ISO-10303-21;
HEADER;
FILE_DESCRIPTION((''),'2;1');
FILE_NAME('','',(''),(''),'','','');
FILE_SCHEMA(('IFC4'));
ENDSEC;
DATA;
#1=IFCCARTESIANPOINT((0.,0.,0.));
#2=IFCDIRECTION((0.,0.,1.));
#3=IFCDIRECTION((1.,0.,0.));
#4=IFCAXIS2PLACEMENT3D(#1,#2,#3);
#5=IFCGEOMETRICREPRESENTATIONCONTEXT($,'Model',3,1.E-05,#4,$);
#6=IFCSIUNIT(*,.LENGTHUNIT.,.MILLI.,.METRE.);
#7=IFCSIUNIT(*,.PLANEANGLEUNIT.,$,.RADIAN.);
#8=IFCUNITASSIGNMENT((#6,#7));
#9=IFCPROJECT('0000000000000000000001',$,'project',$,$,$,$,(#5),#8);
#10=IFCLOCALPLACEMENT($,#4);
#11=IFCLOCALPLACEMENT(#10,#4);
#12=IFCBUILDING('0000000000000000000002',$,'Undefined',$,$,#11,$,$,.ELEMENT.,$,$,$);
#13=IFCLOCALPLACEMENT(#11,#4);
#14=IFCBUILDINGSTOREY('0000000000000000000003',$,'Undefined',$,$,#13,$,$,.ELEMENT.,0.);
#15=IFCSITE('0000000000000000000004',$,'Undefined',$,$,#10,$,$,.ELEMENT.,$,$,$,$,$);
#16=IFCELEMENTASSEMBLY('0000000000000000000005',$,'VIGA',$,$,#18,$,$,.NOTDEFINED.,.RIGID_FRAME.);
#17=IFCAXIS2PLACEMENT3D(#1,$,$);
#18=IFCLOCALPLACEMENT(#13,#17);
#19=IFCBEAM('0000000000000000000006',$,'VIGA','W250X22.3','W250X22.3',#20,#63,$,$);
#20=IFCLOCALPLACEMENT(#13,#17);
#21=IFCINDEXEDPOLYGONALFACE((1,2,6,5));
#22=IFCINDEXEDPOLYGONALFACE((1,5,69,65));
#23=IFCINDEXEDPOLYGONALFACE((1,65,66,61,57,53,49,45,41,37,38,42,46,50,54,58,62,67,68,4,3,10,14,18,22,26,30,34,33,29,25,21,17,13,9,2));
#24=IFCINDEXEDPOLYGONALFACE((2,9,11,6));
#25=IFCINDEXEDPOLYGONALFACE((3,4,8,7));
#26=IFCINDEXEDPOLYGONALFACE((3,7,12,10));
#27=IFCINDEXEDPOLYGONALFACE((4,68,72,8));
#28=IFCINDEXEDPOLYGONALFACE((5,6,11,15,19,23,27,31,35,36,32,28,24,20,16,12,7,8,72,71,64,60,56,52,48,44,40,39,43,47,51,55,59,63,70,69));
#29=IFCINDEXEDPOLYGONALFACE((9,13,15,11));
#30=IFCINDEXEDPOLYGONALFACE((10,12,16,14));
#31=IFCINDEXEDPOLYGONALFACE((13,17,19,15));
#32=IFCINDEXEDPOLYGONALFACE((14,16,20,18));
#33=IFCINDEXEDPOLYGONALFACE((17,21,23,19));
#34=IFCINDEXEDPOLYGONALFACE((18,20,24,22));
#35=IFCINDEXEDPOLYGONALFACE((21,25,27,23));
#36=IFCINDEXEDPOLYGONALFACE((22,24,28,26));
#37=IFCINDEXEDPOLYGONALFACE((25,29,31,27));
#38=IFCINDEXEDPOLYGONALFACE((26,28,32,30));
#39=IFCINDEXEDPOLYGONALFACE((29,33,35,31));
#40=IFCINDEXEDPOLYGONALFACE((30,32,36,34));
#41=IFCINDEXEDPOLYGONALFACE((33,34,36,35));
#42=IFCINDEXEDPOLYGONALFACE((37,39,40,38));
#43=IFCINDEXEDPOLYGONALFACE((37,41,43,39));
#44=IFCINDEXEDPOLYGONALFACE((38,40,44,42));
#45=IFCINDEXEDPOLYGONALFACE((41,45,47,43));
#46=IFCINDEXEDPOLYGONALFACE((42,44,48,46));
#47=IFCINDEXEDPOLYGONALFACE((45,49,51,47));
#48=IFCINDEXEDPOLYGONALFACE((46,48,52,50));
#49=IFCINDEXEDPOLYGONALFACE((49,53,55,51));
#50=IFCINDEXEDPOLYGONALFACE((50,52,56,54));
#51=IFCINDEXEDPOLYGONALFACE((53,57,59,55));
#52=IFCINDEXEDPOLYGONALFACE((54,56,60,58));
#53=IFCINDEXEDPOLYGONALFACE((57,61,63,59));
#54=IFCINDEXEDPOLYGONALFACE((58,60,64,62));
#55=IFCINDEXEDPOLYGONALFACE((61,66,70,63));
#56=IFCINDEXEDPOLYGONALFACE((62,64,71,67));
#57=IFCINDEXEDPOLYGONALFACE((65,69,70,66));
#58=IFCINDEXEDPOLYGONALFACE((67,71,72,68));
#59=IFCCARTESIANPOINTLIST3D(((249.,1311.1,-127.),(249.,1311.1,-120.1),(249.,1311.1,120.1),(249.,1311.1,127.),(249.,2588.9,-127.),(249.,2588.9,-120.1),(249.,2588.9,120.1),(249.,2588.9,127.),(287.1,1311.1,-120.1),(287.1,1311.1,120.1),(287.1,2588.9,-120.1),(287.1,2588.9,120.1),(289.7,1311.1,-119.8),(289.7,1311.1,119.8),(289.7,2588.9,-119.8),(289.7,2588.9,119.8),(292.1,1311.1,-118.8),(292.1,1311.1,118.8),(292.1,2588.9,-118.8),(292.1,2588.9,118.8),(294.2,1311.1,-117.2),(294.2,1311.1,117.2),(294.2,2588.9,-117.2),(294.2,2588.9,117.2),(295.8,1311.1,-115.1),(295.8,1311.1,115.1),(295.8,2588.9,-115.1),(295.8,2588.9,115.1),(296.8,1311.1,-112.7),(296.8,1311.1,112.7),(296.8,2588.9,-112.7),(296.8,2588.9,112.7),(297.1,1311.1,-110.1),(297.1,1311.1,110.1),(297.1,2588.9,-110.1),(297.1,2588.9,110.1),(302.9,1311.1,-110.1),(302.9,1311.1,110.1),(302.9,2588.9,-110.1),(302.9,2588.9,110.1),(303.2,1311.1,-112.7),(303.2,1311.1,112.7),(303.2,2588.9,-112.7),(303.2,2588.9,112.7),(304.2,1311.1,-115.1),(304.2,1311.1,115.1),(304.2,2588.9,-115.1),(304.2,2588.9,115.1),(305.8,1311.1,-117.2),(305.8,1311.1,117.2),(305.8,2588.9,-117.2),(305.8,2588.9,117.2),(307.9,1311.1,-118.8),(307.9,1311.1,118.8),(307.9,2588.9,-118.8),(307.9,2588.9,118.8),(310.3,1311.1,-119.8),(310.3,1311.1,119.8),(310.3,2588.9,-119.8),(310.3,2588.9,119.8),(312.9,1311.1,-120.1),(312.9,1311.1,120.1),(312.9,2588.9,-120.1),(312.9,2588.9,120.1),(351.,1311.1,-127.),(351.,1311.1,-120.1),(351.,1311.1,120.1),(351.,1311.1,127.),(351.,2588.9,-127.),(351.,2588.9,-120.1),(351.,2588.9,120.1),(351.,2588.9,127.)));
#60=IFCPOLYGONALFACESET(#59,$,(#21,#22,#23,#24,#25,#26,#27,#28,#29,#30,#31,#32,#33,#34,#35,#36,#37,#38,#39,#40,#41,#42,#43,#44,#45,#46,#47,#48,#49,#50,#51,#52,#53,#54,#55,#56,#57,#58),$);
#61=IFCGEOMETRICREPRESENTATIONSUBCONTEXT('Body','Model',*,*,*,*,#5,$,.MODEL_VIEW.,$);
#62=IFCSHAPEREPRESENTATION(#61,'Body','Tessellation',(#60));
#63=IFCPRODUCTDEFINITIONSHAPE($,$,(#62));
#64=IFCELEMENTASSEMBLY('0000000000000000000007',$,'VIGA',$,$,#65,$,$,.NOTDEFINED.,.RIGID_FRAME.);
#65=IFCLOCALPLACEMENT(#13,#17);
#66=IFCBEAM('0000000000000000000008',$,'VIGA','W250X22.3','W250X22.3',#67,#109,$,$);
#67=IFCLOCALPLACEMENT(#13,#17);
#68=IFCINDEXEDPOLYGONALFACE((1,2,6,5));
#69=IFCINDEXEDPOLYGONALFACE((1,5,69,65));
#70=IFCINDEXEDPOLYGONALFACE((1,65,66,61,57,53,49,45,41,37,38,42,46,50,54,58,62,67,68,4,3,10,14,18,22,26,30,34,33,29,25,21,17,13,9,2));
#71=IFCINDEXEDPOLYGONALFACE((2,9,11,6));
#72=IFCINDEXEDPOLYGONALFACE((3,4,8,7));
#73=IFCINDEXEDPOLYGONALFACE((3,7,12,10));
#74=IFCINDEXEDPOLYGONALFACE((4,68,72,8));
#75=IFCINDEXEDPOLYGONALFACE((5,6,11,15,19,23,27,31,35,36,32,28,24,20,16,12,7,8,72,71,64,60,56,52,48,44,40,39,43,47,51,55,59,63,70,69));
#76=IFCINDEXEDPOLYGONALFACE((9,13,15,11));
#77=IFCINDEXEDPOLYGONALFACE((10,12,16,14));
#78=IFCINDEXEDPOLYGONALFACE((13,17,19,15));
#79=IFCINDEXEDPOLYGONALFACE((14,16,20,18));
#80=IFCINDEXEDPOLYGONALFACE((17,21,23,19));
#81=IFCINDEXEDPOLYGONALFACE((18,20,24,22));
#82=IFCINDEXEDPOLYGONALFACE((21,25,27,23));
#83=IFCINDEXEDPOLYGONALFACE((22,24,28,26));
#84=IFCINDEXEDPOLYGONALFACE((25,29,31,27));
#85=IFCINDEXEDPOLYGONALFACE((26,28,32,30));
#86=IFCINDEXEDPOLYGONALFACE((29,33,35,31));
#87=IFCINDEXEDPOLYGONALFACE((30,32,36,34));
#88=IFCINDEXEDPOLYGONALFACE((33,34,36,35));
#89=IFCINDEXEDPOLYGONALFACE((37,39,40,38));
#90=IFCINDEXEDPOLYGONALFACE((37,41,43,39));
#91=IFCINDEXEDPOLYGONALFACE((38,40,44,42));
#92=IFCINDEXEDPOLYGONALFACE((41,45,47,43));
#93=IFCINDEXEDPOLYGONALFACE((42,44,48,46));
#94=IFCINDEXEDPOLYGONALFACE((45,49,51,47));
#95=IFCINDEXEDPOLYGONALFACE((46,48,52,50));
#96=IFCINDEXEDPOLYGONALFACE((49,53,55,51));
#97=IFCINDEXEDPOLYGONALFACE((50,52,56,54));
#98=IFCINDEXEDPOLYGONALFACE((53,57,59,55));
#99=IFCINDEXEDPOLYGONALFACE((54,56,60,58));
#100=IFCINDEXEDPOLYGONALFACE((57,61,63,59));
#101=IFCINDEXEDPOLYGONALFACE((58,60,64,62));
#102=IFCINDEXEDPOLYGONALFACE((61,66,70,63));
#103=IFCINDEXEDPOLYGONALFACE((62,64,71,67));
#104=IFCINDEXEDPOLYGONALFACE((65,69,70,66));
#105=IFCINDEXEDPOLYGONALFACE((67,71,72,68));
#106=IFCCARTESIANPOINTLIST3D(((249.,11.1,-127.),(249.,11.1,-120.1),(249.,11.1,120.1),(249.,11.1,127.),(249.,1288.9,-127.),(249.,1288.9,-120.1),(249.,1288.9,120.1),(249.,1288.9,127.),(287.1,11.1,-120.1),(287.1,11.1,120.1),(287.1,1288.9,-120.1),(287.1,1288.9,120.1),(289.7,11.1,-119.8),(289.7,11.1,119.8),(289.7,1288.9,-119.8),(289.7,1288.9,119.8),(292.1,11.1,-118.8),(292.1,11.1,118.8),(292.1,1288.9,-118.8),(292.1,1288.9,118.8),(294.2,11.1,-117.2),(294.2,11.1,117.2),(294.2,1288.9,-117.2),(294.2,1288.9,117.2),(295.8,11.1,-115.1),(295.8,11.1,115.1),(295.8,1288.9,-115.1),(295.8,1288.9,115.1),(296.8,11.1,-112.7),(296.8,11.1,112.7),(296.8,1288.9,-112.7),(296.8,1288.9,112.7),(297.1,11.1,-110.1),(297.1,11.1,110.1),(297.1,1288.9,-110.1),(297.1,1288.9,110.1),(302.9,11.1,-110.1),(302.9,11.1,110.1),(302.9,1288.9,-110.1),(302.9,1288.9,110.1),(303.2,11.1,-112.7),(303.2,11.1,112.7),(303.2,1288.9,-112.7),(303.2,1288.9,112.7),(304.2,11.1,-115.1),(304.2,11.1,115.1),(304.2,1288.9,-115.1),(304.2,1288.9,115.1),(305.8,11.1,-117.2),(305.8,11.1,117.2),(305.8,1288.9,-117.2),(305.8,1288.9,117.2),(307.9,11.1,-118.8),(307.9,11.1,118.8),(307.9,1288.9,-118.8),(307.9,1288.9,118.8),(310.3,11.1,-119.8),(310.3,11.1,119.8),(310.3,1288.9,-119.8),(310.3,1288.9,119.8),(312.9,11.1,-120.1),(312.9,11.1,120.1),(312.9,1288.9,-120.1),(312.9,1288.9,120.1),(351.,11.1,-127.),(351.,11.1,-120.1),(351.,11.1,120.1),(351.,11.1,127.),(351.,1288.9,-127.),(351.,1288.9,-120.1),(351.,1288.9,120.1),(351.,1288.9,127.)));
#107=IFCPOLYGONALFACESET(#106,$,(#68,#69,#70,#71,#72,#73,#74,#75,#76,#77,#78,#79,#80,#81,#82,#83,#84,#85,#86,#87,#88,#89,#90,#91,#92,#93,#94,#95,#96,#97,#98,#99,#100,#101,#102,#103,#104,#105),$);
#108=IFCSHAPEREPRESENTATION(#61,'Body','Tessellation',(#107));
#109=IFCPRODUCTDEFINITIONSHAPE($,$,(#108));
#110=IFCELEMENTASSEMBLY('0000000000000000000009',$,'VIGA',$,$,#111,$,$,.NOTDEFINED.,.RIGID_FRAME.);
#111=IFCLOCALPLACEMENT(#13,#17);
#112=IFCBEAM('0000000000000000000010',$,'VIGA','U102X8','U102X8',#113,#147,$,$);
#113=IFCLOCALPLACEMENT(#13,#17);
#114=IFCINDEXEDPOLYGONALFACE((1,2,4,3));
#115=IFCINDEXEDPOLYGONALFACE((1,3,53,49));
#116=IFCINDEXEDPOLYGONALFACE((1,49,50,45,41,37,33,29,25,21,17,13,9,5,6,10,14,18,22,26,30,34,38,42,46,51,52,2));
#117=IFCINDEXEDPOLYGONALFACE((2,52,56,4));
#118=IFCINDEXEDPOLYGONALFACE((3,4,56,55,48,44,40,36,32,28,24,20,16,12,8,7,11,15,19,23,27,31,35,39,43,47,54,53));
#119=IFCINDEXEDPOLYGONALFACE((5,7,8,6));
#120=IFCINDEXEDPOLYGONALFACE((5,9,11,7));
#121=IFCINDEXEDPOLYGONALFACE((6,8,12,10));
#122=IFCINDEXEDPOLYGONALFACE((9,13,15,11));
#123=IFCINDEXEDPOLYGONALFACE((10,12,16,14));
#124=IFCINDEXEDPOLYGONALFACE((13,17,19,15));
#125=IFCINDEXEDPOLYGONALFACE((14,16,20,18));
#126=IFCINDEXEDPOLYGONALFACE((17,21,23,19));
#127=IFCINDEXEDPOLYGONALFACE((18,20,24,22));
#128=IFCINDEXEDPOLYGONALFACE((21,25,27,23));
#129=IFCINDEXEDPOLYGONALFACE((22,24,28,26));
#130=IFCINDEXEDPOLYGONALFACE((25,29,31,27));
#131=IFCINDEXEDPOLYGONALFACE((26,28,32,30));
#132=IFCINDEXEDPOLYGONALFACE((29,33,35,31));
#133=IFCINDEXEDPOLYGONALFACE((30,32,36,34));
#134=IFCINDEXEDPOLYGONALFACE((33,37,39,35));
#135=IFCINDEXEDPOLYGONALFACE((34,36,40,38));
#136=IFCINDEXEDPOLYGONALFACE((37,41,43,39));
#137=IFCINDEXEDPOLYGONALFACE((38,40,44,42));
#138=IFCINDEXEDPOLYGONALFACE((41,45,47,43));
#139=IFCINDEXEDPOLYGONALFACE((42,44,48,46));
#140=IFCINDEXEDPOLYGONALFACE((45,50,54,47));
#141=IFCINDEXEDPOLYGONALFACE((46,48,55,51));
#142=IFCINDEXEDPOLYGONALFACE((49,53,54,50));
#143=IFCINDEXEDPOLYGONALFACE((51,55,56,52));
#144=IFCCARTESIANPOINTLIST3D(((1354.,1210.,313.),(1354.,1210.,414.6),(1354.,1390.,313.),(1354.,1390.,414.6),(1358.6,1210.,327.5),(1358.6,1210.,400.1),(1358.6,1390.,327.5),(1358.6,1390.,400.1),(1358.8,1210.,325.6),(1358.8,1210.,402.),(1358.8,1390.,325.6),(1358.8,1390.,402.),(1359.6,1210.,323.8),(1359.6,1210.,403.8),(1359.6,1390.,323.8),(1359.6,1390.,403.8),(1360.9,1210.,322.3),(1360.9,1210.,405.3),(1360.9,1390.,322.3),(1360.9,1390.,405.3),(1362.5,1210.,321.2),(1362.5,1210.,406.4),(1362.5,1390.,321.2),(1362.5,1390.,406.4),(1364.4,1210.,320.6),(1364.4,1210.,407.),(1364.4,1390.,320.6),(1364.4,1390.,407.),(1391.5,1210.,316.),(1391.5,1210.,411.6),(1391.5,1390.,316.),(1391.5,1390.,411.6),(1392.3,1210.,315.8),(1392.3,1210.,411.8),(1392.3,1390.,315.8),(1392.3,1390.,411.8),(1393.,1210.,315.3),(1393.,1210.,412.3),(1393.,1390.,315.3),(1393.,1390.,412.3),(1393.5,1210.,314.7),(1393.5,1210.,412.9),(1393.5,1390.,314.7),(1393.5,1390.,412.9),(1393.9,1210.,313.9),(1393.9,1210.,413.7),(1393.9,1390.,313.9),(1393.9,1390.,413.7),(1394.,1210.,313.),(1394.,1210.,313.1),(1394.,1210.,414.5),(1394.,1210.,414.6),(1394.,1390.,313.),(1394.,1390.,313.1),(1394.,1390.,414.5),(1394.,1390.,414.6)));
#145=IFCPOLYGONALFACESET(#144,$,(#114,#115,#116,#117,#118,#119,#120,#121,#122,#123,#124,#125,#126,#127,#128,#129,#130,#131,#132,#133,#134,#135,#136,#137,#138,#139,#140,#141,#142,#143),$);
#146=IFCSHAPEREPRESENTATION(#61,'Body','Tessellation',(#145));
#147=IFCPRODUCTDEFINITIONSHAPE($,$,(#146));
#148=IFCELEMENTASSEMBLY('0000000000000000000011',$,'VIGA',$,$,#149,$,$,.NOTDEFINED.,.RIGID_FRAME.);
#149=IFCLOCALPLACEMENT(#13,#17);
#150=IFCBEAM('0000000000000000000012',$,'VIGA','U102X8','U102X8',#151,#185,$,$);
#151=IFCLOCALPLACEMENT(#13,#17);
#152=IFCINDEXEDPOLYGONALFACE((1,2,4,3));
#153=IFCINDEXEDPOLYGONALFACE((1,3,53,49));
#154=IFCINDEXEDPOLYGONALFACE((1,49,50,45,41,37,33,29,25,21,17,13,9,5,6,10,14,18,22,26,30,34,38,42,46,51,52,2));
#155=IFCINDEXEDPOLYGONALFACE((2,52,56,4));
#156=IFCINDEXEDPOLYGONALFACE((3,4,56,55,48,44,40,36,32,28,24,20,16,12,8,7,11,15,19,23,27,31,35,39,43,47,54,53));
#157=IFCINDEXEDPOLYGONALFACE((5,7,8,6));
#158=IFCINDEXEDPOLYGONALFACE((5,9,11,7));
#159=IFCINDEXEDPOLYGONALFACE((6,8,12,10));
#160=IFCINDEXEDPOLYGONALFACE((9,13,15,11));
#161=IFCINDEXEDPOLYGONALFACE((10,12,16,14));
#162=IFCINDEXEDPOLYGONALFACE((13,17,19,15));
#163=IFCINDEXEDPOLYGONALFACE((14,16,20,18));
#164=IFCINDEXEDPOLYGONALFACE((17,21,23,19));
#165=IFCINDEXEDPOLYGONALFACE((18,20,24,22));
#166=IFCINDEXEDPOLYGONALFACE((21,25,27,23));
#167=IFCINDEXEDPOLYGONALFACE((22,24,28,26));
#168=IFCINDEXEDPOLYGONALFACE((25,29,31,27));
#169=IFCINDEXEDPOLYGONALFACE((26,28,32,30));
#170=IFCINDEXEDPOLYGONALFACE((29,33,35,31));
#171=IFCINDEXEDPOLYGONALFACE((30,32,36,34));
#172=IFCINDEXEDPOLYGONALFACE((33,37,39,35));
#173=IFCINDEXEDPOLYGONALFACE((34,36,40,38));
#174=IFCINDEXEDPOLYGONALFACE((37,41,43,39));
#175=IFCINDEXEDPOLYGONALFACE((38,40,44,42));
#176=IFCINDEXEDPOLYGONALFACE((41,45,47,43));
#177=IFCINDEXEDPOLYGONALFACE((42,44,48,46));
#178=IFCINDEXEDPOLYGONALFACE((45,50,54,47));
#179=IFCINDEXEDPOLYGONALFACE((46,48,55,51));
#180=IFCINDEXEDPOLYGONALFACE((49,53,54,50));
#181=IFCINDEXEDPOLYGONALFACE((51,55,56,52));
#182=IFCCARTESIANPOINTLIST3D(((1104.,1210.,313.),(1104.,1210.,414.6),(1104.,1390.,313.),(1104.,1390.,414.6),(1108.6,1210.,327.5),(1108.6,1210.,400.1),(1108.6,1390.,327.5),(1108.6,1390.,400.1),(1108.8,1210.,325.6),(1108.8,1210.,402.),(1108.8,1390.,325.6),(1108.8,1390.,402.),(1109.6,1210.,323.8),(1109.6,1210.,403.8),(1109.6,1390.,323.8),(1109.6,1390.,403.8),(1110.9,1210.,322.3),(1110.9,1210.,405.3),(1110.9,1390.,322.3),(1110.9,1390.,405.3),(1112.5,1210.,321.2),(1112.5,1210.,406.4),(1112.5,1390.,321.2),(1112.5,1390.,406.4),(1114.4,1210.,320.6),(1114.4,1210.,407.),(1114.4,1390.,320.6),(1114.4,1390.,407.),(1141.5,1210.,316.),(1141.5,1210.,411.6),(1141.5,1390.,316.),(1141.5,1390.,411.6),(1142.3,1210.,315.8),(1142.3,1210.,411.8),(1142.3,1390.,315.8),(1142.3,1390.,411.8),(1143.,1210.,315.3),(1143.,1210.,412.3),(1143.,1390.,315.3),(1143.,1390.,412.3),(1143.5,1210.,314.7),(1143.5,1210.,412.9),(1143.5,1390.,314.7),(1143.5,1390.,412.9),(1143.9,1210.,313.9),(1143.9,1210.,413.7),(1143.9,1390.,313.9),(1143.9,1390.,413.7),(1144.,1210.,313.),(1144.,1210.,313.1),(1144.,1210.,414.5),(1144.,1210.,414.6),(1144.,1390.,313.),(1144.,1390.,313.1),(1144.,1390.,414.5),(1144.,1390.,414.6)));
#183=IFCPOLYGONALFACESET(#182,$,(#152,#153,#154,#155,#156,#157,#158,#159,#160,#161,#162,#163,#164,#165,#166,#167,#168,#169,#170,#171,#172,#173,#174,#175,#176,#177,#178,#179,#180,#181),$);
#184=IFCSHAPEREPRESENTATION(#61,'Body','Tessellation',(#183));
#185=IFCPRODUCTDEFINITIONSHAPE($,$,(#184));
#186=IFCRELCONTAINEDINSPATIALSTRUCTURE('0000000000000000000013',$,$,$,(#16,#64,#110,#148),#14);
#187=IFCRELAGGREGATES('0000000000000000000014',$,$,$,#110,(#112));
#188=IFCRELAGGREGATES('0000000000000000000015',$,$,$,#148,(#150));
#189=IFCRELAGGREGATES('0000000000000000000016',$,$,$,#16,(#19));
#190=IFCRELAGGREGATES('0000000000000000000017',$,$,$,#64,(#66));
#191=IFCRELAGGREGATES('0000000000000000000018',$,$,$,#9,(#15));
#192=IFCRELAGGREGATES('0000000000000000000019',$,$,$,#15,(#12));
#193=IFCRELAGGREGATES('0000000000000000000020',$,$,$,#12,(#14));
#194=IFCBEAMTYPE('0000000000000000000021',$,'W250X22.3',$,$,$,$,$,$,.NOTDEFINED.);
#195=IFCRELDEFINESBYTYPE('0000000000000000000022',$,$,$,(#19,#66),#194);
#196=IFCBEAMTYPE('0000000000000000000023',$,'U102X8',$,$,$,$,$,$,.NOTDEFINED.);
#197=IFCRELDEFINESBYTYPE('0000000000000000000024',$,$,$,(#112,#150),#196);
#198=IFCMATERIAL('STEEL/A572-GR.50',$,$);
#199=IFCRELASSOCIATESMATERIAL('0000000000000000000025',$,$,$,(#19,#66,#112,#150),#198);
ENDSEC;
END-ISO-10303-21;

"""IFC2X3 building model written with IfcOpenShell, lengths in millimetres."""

from ifc_helpers import new_model, si_unit, frame, origin_with_axes, origin_2d_with_axis, place, context, subcontext, project, spatial, i_section, u_section, extrude, material, type_object, element, aggregate, save


model = new_model("IFC2X3")

# Units and contexts
model_context = context("Model", 3, precision=1e-05, world=origin_with_axes())
body_context = subcontext(model_context, "Body", "Model", "MODEL_VIEW")
ifc_project = project(units=[si_unit("LENGTHUNIT", "METRE", prefix="MILLI"), si_unit("PLANEANGLEUNIT", "RADIAN")], contexts=[model_context])

# Site, building, storey
site_placement = place(None, origin_with_axes())
site = spatial("IfcSite", under=ifc_project, at=site_placement, Name="Undefined", CompositionType="ELEMENT")
building_placement = place(site_placement, origin_with_axes())
building = spatial("IfcBuilding", under=site, at=building_placement, Name="Undefined", CompositionType="ELEMENT")
storey_placement = place(building_placement, origin_with_axes())
storey = spatial("IfcBuildingStorey", under=building, at=storey_placement, Name="Undefined", CompositionType="ELEMENT", Elevation=0.0)

# Element assemblies, beams
assembly_1_placement = place(storey_placement, origin_with_axes())
assembly_1 = element("IfcElementAssembly", 1, at=assembly_1_placement, inside=storey, Name="VIGA", AssemblyPlace="NOTDEFINED", PredefinedType="RIGID_FRAME")
ifc_material_1 = material(Name="STEEL/A572-GR.50")
beam_type_1 = type_object("IfcBeamType", Name="W250X22.3", PredefinedType="NOTDEFINED")
beam_1_placement = place(assembly_1_placement, frame((300.0, 1311.1, 0.0), z_axis=(0.0, 0.0, 1.0), x_axis=(0.0, 1.0, 0.0)))
beam_1 = element("IfcBeam", 2, at=beam_1_placement, type_object=beam_type_1, material=ifc_material_1, Name="VIGA", Description="W250X22.3", ObjectType="W250X22.3", context=body_context, shape_type="SweptSolid", body=[
    extrude(i_section(OverallWidth=102.0, OverallDepth=254.0, WebThickness=5.8, FlangeThickness=6.9, FilletRadius=10.0, at=origin_2d_with_axis()), frame((1277.8, 0.0, 0.0), z_axis=(-1.0, 0.0, 0.0), x_axis=(0.0, -1.0, 0.0)), (0.0, 0.0, 1.0), 1277.8),
])
assembly_2_placement = place(storey_placement, origin_with_axes())
assembly_2 = element("IfcElementAssembly", 3, at=assembly_2_placement, inside=storey, Name="VIGA", AssemblyPlace="NOTDEFINED", PredefinedType="RIGID_FRAME")
beam_2_placement = place(assembly_2_placement, frame((300.0, 11.1, 0.0), z_axis=(0.0, 0.0, 1.0), x_axis=(0.0, 1.0, 0.0)))
beam_2 = element("IfcBeam", 4, at=beam_2_placement, type_object=beam_type_1, material=ifc_material_1, Name="VIGA", Description="W250X22.3", ObjectType="W250X22.3", context=body_context, shape_type="SweptSolid", body=[
    extrude(i_section(OverallWidth=102.0, OverallDepth=254.0, WebThickness=5.8, FlangeThickness=6.9, FilletRadius=10.0, at=origin_2d_with_axis()), frame((1277.8, 0.0, 0.0), z_axis=(-1.0, 0.0, 0.0), x_axis=(0.0, -1.0, 0.0)), (0.0, 0.0, 1.0), 1277.8),
])
assembly_3_placement = place(storey_placement, origin_with_axes())
assembly_3 = element("IfcElementAssembly", 5, at=assembly_3_placement, inside=storey, Name="VIGA", AssemblyPlace="NOTDEFINED", PredefinedType="RIGID_FRAME")
beam_type_2 = type_object("IfcBeamType", Name="U102X8", PredefinedType="NOTDEFINED")
beam_3_placement = place(assembly_3_placement, frame((1374.0, 1210.0, 363.8), z_axis=(0.0, 0.0, 1.0), x_axis=(0.0, 1.0, 0.0)))
beam_3 = element("IfcBeam", 6, at=beam_3_placement, type_object=beam_type_2, material=ifc_material_1, Name="VIGA", Description="U102X8", ObjectType="U102X8", context=body_context, shape_type="SweptSolid", body=[
    extrude(u_section(Depth=101.6, FlangeWidth=40.0, WebThickness=4.6, FlangeThickness=6.0, FilletRadius=7.0, EdgeRadius=3.0, FlangeSlope=0.16839, at=origin_2d_with_axis()), frame((180.0, 0.0, 0.0), z_axis=(-1.0, 0.0, 0.0), x_axis=(0.0, -1.0, 0.0)), (0.0, 0.0, 1.0), 180.0),
])
aggregate(assembly_3, [beam_3])
assembly_4_placement = place(storey_placement, origin_with_axes())
assembly_4 = element("IfcElementAssembly", 7, at=assembly_4_placement, inside=storey, Name="VIGA", AssemblyPlace="NOTDEFINED", PredefinedType="RIGID_FRAME")
beam_4_placement = place(assembly_4_placement, frame((1124.0, 1210.0, 363.8), z_axis=(0.0, 0.0, 1.0), x_axis=(0.0, 1.0, 0.0)))
beam_4 = element("IfcBeam", 8, at=beam_4_placement, type_object=beam_type_2, material=ifc_material_1, Name="VIGA", Description="U102X8", ObjectType="U102X8", context=body_context, shape_type="SweptSolid", body=[
    extrude(u_section(Depth=101.6, FlangeWidth=40.0, WebThickness=4.6, FlangeThickness=6.0, FilletRadius=7.0, EdgeRadius=3.0, FlangeSlope=0.16839, at=origin_2d_with_axis()), frame((180.0, 0.0, 0.0), z_axis=(-1.0, 0.0, 0.0), x_axis=(0.0, -1.0, 0.0)), (0.0, 0.0, 1.0), 180.0),
])
aggregate(assembly_4, [beam_4])

aggregate(assembly_1, [beam_1])
aggregate(assembly_2, [beam_2])

save(model, "model.ifc")
